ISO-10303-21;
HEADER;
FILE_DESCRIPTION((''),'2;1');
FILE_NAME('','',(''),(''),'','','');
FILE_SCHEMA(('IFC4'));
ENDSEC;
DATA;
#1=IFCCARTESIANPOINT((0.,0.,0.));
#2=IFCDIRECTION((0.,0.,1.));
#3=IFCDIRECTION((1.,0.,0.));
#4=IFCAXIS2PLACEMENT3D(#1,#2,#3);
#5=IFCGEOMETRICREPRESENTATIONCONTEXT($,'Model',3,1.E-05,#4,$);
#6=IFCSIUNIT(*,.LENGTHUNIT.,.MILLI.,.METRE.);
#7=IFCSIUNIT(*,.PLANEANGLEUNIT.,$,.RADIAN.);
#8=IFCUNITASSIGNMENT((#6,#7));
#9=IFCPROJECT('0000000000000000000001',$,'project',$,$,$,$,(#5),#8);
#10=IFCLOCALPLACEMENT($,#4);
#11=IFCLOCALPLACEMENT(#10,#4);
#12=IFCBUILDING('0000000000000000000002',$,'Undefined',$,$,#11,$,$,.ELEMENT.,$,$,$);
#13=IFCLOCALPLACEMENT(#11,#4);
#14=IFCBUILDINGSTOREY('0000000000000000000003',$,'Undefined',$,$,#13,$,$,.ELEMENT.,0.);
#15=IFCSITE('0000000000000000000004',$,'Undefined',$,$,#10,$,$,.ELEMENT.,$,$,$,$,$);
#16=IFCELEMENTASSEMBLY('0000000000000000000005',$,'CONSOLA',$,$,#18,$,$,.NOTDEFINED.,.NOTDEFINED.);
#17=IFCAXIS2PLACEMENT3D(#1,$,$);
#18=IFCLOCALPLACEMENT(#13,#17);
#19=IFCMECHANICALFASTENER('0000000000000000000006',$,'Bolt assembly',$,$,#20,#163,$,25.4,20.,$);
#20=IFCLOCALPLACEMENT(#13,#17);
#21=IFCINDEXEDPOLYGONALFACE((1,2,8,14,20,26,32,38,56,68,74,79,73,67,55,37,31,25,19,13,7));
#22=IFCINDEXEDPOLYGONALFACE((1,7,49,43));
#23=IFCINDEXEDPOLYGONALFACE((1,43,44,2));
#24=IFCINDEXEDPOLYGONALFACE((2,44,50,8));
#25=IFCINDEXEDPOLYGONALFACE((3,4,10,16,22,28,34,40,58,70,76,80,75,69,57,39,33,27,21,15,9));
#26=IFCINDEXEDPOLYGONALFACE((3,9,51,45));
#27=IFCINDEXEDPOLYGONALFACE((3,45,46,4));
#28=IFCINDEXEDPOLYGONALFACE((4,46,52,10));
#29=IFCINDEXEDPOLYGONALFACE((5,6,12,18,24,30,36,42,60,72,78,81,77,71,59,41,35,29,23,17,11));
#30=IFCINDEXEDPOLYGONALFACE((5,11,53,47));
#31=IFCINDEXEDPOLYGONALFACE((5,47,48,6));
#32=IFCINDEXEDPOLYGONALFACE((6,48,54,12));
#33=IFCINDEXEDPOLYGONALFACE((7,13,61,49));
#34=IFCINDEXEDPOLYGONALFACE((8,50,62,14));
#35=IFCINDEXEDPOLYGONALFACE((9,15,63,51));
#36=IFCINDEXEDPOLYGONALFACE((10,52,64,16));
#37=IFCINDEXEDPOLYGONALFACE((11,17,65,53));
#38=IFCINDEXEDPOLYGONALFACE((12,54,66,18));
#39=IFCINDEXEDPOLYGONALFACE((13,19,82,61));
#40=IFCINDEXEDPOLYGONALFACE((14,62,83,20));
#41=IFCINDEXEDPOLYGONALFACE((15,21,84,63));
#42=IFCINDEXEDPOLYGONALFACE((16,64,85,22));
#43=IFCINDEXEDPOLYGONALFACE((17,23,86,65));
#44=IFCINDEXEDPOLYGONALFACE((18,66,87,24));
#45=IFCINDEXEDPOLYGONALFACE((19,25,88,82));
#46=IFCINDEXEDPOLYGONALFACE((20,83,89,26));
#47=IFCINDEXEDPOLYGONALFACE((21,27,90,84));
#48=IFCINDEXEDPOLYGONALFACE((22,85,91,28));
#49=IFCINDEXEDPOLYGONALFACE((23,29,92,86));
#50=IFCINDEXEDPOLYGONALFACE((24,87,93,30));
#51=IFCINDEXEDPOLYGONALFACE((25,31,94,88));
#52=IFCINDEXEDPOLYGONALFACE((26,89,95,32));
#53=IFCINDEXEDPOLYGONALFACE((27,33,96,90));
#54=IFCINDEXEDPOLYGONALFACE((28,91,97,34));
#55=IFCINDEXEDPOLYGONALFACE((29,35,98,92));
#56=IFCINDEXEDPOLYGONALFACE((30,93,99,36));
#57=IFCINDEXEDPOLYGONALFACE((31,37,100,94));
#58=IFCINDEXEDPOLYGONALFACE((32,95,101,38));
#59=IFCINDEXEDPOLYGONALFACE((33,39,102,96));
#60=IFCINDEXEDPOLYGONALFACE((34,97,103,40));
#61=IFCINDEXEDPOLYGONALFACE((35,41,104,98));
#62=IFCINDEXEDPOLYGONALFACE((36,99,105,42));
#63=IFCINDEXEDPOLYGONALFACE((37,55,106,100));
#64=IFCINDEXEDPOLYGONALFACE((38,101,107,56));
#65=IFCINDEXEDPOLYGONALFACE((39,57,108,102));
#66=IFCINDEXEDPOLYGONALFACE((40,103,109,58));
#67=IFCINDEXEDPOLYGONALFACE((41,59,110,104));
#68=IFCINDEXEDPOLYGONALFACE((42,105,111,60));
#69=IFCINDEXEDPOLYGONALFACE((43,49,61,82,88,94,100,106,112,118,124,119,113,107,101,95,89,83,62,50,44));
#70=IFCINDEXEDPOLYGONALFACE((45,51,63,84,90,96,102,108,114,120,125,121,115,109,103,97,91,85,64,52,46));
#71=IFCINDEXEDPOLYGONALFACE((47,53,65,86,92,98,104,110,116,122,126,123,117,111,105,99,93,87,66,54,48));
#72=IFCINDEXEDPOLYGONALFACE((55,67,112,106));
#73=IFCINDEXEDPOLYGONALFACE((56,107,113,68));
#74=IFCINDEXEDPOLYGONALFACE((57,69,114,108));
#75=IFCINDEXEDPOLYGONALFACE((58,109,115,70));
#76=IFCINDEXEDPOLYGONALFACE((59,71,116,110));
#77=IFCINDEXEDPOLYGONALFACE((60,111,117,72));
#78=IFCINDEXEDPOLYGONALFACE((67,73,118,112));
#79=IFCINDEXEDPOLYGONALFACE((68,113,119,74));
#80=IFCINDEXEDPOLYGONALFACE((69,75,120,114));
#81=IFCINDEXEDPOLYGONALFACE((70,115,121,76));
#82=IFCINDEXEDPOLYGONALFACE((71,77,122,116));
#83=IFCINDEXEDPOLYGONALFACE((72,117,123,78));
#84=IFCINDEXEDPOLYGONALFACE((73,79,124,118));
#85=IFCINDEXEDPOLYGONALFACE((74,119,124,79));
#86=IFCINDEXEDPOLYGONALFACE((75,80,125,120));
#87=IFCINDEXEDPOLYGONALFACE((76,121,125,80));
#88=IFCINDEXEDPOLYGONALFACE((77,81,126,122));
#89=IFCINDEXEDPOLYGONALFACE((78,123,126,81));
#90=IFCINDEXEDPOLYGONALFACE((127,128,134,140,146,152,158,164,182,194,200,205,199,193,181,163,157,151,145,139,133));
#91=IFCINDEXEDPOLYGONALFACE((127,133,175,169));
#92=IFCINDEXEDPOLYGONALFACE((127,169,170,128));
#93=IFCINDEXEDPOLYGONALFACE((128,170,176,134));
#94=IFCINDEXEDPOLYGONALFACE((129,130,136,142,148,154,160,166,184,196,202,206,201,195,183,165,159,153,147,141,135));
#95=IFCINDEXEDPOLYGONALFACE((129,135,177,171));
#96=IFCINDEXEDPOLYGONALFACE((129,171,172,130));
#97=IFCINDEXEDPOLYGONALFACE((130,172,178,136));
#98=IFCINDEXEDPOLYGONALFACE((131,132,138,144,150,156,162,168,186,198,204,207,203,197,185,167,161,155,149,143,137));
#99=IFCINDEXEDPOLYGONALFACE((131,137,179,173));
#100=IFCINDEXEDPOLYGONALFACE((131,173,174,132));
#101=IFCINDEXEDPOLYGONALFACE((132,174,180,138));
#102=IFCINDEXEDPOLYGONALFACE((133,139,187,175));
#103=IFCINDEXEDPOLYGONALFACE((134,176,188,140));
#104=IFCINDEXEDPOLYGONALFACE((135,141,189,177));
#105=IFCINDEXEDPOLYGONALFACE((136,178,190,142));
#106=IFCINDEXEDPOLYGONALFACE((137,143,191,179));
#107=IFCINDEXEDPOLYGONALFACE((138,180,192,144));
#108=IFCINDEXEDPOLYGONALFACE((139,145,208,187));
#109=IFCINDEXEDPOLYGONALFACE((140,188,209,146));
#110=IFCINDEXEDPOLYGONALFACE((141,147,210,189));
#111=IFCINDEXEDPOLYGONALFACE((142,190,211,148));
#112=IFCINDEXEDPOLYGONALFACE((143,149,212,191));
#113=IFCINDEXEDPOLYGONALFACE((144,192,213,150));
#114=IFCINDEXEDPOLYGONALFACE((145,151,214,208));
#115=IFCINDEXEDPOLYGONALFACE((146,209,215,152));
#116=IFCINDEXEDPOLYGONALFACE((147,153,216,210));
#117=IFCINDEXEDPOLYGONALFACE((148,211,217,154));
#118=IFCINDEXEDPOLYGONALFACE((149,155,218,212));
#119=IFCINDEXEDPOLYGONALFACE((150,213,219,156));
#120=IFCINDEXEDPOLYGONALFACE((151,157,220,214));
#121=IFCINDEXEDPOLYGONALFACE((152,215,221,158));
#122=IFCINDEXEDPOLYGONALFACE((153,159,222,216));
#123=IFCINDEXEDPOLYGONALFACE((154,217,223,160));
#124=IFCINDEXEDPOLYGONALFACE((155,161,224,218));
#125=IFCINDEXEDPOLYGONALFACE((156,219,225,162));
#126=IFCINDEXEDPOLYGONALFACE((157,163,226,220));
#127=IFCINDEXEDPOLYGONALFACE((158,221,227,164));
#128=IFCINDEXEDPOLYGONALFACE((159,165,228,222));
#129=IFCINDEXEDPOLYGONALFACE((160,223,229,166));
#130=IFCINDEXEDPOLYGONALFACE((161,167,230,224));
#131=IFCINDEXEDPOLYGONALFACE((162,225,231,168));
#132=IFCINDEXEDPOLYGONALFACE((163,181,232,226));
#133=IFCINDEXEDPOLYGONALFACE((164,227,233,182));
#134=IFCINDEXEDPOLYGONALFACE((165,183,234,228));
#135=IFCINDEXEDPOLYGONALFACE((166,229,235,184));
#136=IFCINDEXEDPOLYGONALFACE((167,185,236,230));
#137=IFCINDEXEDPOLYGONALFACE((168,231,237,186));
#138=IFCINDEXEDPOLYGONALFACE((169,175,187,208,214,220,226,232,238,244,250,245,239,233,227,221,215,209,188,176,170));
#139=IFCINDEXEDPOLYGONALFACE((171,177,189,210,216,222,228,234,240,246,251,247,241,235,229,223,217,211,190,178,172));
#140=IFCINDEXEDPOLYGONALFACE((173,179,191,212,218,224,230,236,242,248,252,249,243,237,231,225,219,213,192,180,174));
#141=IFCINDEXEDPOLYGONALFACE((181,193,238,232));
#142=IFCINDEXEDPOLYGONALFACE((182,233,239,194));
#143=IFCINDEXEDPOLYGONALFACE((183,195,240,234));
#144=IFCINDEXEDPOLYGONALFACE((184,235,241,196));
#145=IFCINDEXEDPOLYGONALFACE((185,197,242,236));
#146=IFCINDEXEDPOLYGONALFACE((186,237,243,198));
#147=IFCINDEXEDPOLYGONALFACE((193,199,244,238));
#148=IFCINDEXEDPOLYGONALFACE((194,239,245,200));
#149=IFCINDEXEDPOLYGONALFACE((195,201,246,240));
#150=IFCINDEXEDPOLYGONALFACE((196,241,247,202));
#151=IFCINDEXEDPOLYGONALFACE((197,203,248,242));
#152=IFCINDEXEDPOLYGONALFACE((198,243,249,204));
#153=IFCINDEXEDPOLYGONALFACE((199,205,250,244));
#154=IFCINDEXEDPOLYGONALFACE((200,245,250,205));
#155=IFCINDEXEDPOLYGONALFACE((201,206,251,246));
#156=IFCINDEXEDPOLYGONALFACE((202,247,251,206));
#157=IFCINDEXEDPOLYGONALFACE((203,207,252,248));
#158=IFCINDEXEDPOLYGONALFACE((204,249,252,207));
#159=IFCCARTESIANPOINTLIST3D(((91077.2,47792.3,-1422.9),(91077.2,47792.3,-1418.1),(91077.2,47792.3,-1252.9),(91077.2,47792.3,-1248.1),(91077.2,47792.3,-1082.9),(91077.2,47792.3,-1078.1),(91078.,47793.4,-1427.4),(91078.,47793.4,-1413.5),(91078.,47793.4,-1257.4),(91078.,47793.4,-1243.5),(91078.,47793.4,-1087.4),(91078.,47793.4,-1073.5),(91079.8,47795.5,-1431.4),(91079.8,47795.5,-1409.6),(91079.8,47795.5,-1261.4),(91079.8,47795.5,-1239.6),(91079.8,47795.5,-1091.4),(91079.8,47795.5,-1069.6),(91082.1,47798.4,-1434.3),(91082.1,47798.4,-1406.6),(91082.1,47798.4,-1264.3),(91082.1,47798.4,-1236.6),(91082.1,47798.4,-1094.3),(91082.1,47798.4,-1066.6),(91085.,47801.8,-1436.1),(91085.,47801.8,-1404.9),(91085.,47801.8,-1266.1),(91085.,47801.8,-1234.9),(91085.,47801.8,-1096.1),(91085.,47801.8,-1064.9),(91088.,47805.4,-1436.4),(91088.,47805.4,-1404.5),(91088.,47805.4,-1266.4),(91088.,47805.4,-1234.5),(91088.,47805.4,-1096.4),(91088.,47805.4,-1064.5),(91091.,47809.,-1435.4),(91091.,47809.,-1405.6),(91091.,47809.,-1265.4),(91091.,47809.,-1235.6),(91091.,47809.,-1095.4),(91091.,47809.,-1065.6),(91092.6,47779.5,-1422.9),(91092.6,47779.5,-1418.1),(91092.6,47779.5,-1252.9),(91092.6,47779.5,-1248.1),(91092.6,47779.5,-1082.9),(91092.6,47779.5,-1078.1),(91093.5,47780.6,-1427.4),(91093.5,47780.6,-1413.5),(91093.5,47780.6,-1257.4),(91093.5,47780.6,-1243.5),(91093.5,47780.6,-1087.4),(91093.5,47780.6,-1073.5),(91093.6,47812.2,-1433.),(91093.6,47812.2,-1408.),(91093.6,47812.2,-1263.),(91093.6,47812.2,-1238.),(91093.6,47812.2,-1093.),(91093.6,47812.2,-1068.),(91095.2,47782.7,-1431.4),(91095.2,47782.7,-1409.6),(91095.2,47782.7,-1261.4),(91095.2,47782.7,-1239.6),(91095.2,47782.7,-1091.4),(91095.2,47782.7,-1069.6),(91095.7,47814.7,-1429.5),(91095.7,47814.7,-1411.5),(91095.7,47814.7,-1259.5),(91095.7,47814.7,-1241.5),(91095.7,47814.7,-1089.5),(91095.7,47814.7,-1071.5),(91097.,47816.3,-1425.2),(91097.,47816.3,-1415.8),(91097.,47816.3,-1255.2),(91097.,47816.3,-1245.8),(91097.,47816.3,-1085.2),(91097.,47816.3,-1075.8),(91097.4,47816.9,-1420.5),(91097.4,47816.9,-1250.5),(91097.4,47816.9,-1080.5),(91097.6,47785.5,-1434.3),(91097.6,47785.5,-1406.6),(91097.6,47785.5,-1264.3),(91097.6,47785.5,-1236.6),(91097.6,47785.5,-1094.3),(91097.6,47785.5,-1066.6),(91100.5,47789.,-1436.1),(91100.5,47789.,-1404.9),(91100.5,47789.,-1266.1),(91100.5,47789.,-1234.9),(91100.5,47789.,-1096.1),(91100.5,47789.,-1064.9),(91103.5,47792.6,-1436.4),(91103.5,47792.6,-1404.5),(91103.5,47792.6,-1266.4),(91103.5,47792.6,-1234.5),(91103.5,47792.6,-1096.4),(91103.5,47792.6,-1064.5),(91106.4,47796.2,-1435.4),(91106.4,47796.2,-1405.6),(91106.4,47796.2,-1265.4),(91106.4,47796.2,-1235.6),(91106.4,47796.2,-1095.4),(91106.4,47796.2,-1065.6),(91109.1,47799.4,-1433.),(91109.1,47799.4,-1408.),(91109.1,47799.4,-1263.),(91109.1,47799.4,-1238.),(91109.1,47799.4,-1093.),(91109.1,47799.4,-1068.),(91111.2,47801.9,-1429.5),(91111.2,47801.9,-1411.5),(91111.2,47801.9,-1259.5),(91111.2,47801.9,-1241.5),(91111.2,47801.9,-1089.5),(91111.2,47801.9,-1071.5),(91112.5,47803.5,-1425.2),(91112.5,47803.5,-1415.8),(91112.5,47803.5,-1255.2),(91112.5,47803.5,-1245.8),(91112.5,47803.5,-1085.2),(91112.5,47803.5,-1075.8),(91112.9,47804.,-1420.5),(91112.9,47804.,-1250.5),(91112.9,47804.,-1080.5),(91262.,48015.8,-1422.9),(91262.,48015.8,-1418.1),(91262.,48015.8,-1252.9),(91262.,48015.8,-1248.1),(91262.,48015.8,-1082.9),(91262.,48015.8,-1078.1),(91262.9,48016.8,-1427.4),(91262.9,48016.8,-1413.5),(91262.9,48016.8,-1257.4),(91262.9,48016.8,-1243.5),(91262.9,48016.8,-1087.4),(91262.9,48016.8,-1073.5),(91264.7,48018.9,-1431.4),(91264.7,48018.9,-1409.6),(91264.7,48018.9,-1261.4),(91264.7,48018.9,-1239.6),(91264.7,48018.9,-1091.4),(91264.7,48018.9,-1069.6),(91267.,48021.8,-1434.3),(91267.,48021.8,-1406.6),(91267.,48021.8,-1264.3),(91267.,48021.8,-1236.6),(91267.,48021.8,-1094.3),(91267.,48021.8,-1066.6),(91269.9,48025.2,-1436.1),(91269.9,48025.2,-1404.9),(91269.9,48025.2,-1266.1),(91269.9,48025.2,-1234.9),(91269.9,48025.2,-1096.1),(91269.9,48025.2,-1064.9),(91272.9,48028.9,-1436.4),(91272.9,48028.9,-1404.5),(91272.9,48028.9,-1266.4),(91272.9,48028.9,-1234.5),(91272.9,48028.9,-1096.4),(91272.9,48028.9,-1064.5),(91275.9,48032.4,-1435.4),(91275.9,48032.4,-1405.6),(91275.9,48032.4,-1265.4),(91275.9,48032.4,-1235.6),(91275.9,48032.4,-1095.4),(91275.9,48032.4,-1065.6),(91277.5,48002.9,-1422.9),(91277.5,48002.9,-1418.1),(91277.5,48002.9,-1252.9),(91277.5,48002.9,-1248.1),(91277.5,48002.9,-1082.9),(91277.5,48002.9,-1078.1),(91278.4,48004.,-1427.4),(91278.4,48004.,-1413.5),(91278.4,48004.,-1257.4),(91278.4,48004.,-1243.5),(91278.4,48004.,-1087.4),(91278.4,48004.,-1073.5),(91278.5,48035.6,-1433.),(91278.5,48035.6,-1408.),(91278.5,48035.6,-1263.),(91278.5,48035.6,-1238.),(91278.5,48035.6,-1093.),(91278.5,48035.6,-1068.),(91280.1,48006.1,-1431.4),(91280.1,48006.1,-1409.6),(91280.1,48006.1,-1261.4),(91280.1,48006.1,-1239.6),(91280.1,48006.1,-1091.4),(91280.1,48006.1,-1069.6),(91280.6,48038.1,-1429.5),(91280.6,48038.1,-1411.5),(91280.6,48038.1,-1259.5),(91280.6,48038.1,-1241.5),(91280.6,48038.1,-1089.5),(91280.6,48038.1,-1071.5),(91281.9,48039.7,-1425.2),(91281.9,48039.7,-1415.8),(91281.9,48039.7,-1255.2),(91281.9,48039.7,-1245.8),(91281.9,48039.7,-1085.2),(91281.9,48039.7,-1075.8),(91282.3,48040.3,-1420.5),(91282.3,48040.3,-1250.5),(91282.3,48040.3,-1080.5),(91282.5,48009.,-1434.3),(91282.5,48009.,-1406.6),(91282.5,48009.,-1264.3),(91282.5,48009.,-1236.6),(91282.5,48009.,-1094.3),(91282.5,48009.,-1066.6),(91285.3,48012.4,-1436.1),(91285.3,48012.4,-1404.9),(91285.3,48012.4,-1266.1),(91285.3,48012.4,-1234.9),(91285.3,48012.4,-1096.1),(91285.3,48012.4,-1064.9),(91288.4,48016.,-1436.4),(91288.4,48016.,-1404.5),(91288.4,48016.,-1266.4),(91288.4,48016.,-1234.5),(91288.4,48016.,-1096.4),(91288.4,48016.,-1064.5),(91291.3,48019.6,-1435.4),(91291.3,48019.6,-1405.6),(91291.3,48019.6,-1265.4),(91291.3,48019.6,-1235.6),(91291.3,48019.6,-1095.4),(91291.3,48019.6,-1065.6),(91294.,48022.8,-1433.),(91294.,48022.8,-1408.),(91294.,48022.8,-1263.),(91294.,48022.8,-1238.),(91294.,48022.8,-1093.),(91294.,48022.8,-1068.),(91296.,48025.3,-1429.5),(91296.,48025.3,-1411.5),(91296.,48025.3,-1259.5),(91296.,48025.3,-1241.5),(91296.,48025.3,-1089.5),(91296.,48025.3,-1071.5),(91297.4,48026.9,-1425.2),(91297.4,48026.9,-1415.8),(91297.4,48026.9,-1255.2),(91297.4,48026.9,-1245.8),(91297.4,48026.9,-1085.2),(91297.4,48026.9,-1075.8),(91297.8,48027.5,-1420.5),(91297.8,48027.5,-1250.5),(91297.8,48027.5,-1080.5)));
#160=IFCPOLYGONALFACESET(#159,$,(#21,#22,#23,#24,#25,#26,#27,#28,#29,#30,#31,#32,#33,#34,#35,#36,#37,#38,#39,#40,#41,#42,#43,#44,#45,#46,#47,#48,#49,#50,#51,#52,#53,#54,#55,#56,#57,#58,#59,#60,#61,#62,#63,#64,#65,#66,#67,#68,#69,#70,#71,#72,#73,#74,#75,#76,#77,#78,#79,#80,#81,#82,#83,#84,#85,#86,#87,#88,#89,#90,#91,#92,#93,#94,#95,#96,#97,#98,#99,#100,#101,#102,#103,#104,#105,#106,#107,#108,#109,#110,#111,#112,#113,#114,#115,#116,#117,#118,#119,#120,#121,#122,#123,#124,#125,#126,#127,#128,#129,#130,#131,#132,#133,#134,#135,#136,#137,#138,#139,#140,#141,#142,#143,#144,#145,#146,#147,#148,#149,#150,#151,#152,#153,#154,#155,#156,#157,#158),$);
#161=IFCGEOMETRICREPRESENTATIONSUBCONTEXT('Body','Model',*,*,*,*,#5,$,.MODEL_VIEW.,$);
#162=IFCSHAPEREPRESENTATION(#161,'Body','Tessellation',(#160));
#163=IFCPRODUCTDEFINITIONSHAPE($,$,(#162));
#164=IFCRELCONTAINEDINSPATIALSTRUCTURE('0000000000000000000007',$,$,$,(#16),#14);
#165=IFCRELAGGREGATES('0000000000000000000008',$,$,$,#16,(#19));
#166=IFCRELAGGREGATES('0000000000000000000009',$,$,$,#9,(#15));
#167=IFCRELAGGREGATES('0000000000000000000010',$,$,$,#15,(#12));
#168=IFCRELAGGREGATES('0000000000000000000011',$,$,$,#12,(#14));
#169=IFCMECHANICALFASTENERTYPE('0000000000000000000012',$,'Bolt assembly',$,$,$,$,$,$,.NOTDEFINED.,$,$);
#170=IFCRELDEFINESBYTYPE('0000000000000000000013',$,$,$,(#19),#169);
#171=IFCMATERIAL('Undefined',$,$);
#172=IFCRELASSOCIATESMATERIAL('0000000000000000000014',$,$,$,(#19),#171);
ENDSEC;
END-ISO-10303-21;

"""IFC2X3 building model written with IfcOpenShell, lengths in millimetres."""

from ifc_helpers import new_model, si_unit, frame, origin_with_axes, origin_2d_with_axis, place, context, subcontext, project, spatial, circle, extrude, source, transform, mapped, material, type_object, element, aggregate, save


model = new_model("IFC2X3")

# Units and contexts
model_context = context("Model", 3, precision=1e-05, world=origin_with_axes())
body_context = subcontext(model_context, "Body", "Model", "MODEL_VIEW")
ifc_project = project(units=[si_unit("LENGTHUNIT", "METRE", prefix="MILLI"), si_unit("PLANEANGLEUNIT", "RADIAN")], contexts=[model_context])

# Site, building, storey
site_placement = place(None, origin_with_axes())
site = spatial("IfcSite", under=ifc_project, at=site_placement, Name="Undefined", CompositionType="ELEMENT")
building_placement = place(site_placement, origin_with_axes())
building = spatial("IfcBuilding", under=site, at=building_placement, Name="Undefined", CompositionType="ELEMENT")
storey_placement = place(building_placement, origin_with_axes())
storey = spatial("IfcBuildingStorey", under=building, at=storey_placement, Name="Undefined", CompositionType="ELEMENT", Elevation=0.0)

# Element assembly
assembly_1_placement = place(storey_placement, origin_with_axes())
assembly_1 = element("IfcElementAssembly", 1, at=assembly_1_placement, inside=storey, Name="CONSOLA", AssemblyPlace="NOTDEFINED", PredefinedType="NOTDEFINED")

# Mechanical fastener
ifc_material_1 = material(Name="Undefined")
mechanical_fastener_type = type_object("IfcMechanicalFastenerType", Name="Bolt assembly")
shared_shape_1 = source(origin_with_axes(), body_context, "Body", "SweptSolid", [
    extrude(circle(Radius=16.0, at=origin_2d_with_axis()), frame((0.0, -4.0, 0.0), z_axis=(0.0, 1.0, 0.0), x_axis=(1.0, 0.0, 0.0)), (0.0, 0.0, 1.0), 20.1),
])
mechanical_fastener_1_placement = place(assembly_1_placement, frame((91099.6, 47794.3, -1250.5), z_axis=(0.000001, 0.000001, 1.0), x_axis=(0.63756, 0.770401, -0.000002)))
mechanical_fastener_1 = element("IfcMechanicalFastener", 2, at=mechanical_fastener_1_placement, type_object=mechanical_fastener_type, material=ifc_material_1, Name="Bolt assembly", NominalDiameter=25.4, NominalLength=20.0, context=body_context, shape_type="MappedRepresentation", body=[
    mapped(shared_shape_1, transform((0.0, 0.0, -170.0))),
    mapped(shared_shape_1, transform((290.0, 0.0, -170.0))),
    mapped(shared_shape_1, transform((0.0, 0.0, 0.0))),
    mapped(shared_shape_1, transform((290.0, 0.0, 0.0))),
    mapped(shared_shape_1, transform((0.0, 0.0, 170.0))),
    mapped(shared_shape_1, transform((290.0, 0.0, 170.0))),
])
aggregate(assembly_1, [mechanical_fastener_1])

save(model, "model.ifc")
